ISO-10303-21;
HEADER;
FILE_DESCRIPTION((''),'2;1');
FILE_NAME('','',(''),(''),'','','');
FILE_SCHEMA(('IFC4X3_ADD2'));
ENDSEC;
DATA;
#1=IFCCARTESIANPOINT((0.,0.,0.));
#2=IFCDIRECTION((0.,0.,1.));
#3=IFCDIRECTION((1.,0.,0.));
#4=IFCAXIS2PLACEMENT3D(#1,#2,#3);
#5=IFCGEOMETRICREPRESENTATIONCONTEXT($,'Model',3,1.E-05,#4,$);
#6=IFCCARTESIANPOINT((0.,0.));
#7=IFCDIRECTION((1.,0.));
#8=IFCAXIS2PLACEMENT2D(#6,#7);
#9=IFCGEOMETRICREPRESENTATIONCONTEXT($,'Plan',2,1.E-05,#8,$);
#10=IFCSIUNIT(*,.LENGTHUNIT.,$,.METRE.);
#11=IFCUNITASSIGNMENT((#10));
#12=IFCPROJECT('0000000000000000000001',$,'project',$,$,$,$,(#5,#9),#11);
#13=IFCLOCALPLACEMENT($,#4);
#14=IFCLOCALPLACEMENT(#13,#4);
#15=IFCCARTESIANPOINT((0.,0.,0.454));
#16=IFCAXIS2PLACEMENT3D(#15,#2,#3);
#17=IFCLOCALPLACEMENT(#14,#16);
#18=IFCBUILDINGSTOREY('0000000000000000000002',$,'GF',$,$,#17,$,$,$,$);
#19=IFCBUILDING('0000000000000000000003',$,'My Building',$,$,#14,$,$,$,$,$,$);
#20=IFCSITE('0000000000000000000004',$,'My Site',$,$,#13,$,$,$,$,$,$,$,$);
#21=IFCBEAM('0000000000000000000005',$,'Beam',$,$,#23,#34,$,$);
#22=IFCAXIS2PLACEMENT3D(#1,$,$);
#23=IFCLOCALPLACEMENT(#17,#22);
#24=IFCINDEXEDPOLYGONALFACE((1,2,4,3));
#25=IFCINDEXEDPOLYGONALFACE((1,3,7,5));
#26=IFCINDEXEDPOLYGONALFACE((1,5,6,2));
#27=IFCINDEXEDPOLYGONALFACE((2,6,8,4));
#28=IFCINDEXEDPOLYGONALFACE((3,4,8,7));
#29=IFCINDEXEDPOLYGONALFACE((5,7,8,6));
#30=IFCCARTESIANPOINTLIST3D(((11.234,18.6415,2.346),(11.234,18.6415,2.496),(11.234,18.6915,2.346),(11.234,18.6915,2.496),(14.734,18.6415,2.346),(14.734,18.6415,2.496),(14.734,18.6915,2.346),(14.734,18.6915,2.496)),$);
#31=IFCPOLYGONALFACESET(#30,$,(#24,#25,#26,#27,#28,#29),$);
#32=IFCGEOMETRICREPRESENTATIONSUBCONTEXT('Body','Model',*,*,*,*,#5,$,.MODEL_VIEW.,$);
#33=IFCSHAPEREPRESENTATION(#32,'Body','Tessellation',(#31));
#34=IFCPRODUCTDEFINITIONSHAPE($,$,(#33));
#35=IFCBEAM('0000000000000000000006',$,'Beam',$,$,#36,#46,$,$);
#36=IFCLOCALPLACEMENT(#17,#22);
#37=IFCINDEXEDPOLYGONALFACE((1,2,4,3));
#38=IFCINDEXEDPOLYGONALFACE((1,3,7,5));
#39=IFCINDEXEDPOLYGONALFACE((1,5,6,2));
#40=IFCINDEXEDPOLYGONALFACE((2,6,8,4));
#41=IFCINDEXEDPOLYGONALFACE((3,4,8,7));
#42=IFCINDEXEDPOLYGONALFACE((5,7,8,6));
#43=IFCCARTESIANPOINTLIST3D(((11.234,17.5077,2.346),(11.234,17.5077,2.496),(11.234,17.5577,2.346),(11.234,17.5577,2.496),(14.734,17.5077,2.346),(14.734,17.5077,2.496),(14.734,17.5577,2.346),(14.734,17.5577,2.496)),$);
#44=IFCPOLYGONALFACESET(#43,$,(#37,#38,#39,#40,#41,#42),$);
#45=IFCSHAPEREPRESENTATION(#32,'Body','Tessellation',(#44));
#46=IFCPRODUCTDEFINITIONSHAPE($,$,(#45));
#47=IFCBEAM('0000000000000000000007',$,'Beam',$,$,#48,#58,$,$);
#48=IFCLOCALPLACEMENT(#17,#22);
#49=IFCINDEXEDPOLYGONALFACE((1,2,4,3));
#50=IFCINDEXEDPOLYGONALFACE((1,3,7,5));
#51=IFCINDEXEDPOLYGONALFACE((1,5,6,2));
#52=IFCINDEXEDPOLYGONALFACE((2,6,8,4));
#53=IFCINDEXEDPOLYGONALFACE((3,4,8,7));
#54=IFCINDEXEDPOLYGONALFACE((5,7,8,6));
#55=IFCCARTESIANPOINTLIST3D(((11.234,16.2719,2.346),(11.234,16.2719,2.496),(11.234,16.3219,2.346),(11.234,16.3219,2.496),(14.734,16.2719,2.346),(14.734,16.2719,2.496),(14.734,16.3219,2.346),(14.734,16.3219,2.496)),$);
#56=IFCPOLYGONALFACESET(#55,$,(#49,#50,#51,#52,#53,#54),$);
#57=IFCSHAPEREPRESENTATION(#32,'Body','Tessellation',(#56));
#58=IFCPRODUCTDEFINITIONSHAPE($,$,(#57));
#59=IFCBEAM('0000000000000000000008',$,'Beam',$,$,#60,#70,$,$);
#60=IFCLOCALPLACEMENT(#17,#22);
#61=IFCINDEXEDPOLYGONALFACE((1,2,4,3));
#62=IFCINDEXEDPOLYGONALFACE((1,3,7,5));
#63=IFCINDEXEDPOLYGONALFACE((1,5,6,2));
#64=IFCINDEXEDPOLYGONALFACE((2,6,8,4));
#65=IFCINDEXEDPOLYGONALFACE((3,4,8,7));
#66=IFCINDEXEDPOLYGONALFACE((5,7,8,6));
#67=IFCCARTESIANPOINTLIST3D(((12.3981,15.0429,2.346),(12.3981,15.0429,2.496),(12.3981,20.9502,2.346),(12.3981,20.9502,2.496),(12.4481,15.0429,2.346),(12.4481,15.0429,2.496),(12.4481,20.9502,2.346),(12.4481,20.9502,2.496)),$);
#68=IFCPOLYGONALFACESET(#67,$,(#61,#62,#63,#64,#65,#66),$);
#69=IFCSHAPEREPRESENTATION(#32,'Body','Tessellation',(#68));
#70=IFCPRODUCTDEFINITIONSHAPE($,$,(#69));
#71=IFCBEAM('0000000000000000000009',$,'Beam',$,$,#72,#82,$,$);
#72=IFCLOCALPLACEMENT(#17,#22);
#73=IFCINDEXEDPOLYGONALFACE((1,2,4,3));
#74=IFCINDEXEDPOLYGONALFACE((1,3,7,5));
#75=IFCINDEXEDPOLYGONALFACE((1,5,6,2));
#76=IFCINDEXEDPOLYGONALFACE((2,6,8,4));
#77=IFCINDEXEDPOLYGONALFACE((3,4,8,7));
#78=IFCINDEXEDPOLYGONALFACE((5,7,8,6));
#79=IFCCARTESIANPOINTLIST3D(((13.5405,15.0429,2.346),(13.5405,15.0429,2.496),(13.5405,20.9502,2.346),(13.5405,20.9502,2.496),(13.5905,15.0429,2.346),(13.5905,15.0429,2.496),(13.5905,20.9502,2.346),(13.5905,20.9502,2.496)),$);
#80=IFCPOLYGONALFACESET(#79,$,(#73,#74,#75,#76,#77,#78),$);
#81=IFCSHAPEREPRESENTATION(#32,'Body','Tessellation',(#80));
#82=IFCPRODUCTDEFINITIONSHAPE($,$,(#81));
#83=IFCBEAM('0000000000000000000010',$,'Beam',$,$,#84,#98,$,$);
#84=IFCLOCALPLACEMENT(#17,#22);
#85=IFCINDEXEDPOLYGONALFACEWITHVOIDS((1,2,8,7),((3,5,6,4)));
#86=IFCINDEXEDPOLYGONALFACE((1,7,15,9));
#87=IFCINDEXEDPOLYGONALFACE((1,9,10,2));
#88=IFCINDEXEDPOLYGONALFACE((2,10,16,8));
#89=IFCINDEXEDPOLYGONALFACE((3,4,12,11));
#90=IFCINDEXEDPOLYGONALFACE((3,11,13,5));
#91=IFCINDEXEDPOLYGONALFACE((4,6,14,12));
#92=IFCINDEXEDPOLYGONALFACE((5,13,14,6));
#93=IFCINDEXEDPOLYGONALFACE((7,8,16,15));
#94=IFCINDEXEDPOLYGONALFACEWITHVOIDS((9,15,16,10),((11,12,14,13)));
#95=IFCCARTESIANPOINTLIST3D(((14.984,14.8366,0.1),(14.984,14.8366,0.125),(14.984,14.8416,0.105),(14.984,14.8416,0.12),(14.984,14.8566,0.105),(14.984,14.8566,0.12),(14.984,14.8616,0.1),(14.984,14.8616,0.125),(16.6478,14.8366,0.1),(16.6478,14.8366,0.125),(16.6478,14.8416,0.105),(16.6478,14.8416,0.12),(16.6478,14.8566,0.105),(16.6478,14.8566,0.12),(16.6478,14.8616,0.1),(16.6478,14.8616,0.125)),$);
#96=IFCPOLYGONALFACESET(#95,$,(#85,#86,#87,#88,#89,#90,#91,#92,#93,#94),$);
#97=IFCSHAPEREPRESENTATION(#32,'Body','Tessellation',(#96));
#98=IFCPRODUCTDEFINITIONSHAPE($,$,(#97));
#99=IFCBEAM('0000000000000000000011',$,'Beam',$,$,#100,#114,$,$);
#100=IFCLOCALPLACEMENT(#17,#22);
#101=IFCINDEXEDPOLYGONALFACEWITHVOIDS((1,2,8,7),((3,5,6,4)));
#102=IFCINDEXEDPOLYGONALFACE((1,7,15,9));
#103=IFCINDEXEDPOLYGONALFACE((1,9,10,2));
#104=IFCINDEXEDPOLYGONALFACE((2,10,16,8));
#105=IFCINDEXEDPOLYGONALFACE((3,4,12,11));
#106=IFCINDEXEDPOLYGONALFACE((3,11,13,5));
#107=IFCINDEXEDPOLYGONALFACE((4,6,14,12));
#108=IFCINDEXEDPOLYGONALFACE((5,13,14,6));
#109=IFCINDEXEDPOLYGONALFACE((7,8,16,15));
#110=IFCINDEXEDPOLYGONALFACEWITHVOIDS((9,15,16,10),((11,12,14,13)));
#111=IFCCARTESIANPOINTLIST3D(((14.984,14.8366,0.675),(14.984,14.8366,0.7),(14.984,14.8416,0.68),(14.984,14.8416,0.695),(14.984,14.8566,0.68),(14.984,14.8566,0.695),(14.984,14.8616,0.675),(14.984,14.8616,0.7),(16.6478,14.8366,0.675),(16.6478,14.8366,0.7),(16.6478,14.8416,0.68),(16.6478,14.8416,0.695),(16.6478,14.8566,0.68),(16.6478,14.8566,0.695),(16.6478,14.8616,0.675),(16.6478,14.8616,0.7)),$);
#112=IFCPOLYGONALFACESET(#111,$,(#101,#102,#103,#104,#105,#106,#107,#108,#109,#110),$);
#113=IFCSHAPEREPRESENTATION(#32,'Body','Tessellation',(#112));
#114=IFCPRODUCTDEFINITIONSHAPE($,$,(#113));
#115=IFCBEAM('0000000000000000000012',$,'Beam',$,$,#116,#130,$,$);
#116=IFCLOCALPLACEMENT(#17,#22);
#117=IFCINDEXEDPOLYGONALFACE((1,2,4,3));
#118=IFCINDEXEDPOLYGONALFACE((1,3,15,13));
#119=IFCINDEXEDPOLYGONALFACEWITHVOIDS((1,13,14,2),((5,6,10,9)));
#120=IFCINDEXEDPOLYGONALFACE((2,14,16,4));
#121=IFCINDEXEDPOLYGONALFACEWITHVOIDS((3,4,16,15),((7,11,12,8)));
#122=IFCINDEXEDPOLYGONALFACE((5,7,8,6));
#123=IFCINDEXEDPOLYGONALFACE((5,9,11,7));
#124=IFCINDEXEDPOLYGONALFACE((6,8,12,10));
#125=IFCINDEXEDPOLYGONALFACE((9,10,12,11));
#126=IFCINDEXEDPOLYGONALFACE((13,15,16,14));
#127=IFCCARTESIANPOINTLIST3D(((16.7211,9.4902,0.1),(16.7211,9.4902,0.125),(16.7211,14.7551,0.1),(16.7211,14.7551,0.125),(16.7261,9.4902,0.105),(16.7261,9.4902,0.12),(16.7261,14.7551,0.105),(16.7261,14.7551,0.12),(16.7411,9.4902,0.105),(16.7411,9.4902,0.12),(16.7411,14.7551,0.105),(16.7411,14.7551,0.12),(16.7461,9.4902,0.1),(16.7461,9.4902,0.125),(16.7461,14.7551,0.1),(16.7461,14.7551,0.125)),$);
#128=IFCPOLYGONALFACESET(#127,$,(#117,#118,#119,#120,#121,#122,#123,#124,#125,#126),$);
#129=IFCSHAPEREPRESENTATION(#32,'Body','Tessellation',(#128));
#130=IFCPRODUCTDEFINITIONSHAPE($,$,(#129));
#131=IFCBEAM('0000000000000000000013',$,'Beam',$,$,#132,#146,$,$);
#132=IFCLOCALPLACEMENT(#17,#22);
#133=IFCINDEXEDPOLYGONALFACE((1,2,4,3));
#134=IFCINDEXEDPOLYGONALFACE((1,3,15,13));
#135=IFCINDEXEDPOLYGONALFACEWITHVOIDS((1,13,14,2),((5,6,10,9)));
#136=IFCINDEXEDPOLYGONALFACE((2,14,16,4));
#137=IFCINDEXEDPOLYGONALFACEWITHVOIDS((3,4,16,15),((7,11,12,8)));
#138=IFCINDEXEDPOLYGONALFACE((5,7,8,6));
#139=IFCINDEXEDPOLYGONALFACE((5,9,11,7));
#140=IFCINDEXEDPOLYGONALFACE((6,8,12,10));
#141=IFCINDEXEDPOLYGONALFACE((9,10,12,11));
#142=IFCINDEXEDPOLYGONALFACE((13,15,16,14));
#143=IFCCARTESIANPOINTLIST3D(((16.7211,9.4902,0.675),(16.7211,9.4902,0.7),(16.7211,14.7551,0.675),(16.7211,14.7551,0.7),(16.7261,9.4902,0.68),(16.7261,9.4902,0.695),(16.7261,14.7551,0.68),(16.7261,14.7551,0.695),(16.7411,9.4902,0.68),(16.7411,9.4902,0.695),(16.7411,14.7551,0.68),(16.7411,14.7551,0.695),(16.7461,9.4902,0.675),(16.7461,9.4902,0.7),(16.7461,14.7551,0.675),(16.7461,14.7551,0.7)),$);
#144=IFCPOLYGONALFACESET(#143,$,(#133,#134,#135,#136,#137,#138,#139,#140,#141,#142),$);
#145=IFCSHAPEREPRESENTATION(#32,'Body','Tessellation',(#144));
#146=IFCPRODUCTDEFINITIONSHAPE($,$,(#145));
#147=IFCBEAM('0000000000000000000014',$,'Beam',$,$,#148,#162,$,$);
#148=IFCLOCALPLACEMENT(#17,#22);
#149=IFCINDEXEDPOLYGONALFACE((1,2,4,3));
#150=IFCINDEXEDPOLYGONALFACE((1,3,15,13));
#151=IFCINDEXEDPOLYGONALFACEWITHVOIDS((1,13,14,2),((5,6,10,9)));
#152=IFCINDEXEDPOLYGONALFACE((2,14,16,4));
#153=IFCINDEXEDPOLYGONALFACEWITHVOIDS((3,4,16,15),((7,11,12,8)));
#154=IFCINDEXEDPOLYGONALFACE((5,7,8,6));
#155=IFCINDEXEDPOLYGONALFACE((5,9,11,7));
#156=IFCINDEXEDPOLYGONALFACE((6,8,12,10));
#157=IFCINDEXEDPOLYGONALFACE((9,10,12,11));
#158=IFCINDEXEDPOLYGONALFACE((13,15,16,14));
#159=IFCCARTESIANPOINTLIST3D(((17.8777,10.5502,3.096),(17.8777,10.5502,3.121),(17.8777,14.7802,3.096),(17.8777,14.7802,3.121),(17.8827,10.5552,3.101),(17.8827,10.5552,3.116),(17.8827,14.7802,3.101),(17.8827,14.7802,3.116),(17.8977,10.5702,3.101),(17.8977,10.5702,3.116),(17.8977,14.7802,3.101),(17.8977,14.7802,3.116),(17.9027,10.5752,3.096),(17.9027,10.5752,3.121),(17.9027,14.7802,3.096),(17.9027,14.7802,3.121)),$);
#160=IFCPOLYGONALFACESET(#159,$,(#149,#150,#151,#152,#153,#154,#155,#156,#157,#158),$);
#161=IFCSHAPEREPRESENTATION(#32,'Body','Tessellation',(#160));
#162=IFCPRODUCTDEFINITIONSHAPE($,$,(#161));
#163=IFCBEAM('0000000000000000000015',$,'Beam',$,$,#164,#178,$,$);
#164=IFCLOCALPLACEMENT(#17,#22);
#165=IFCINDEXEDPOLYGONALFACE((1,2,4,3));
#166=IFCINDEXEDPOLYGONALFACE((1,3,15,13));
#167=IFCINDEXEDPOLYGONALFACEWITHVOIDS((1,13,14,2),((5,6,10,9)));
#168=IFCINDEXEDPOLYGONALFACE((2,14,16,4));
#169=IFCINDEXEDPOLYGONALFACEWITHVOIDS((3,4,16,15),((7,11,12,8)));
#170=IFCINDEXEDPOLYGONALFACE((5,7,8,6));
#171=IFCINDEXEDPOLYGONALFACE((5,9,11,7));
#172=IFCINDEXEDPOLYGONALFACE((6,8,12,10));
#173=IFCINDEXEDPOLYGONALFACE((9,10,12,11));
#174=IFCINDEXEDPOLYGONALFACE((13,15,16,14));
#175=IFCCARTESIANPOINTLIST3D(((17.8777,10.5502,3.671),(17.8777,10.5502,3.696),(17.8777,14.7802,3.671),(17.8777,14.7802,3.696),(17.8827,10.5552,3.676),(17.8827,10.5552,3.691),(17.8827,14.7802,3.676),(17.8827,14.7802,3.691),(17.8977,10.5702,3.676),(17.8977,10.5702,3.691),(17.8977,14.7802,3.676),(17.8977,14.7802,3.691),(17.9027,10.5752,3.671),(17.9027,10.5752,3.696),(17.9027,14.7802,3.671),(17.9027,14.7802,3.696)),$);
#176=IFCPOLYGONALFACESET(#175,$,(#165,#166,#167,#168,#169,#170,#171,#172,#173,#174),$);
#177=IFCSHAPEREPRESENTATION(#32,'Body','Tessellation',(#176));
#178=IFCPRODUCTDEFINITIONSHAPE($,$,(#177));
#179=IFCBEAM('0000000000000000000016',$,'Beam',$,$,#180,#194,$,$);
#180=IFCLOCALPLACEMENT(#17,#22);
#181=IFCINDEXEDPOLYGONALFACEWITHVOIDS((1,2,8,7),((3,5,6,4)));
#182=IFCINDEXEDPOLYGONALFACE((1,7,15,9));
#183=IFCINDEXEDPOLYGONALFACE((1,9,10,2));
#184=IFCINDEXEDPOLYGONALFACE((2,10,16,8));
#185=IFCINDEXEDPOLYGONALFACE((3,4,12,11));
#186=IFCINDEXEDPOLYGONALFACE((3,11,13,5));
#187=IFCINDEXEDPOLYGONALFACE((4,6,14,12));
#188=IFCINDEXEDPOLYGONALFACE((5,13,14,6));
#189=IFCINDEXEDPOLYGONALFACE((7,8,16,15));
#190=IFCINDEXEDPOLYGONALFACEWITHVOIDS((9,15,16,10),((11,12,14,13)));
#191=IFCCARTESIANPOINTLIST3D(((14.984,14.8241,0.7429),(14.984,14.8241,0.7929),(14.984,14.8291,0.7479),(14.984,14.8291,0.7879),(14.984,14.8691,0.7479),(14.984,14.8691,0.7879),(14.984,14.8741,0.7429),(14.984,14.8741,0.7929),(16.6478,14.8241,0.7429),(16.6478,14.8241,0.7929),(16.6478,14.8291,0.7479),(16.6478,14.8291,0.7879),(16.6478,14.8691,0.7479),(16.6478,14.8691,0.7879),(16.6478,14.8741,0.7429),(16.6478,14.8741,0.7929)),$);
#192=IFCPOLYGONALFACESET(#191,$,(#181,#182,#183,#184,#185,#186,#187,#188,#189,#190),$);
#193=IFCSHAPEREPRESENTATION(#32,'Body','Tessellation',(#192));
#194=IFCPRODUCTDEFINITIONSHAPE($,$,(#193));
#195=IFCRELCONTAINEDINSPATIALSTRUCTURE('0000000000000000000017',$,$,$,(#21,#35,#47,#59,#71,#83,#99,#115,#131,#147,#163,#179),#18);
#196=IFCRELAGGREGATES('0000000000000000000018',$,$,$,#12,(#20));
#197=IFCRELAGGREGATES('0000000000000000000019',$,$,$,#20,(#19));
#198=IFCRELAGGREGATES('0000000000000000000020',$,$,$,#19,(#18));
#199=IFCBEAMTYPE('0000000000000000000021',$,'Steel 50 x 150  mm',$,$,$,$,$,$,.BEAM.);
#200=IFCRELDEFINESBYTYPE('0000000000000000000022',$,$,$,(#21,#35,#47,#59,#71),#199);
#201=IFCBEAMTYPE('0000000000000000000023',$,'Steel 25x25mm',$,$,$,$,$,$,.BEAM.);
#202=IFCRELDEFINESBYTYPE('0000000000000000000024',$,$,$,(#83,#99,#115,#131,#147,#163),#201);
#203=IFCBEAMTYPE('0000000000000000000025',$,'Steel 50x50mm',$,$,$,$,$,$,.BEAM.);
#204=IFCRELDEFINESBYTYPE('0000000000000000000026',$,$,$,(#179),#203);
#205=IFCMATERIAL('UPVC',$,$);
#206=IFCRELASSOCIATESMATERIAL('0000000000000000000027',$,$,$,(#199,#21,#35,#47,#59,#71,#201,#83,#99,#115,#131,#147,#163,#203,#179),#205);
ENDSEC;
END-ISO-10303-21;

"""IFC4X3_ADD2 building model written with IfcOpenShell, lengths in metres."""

from ifc_helpers import new_model, si_unit, frame, origin_with_axes, origin_2d_with_axis, place, context, subcontext, project, spatial, rectangle, hollow_rectangle, extrude, clip, halfspace, material, material_profile, profile_set, profile_usage, type_object, element, save


model = new_model("IFC4X3_ADD2")

# Units and contexts
model_context = context("Model", 3, precision=1e-05, world=origin_with_axes())
plan_context = context("Plan", 2, precision=1e-05, world=origin_2d_with_axis())
body_context = subcontext(model_context, "Body", "Model", "MODEL_VIEW")
ifc_project = project(units=[si_unit("LENGTHUNIT", "METRE")], contexts=[model_context, plan_context])

# Site, building, storey
site_placement = place(None, origin_with_axes())
site = spatial("IfcSite", under=ifc_project, at=site_placement, Name="My Site")
building_placement = place(site_placement, origin_with_axes())
building = spatial("IfcBuilding", under=site, at=building_placement, Name="My Building")
storey_placement = place(building_placement, frame((0.0, 0.0, 0.454), z_axis=(0.0, 0.0, 1.0), x_axis=(1.0, 0.0, 0.0)))
storey = spatial("IfcBuildingStorey", under=building, at=storey_placement, Name="GF")

# Shared definitions
ifc_material_1 = material(Name="UPVC")

# Beams
ifc_material_profile_1 = material_profile(ifc_material_1, rectangle(XDim=0.05, YDim=0.15))
ifc_profile_set_1 = profile_set([ifc_material_profile_1])
beam_type_1 = type_object("IfcBeamType", Name="Steel 50 x 150  mm", PredefinedType="BEAM", material=ifc_profile_set_1)
ifc_profile_usage_1 = profile_usage(ifc_profile_set_1)
beam_1_placement = place(storey_placement, frame((11.234, 18.6665, 2.421), z_axis=(1.0, 0.0, 0.0), x_axis=(0.0, 1.0, 0.0)))
element("IfcBeam", 1, at=beam_1_placement, inside=storey, type_object=beam_type_1, material=ifc_profile_usage_1, Name="Beam", context=body_context, shape_type="SweptSolid", body=[
    extrude(rectangle(XDim=0.05, YDim=0.15), origin_with_axes(), (0.0, 0.0, 1.0), 3.5),
])
ifc_profile_usage_2 = profile_usage(ifc_profile_set_1)
beam_2_placement = place(storey_placement, frame((11.234, 17.5327, 2.421), z_axis=(1.0, 0.0, 0.0), x_axis=(0.0, 1.0, 0.0)))
element("IfcBeam", 2, at=beam_2_placement, inside=storey, type_object=beam_type_1, material=ifc_profile_usage_2, Name="Beam", context=body_context, shape_type="SweptSolid", body=[
    extrude(rectangle(XDim=0.05, YDim=0.15), origin_with_axes(), (0.0, 0.0, 1.0), 3.5),
])
ifc_profile_usage_3 = profile_usage(ifc_profile_set_1)
beam_3_placement = place(storey_placement, frame((11.234, 16.2969, 2.421), z_axis=(1.0, 0.0, 0.0), x_axis=(0.0, 1.0, 0.0)))
element("IfcBeam", 3, at=beam_3_placement, inside=storey, type_object=beam_type_1, material=ifc_profile_usage_3, Name="Beam", context=body_context, shape_type="SweptSolid", body=[
    extrude(rectangle(XDim=0.05, YDim=0.15), origin_with_axes(), (0.0, 0.0, 1.0), 3.5),
])
ifc_profile_usage_4 = profile_usage(ifc_profile_set_1)
beam_4_placement = place(storey_placement, frame((12.4231, 15.0429, 2.421), z_axis=(0.0, 1.0, 0.0), x_axis=(-1.0, 0.0, 0.0)))
element("IfcBeam", 4, at=beam_4_placement, inside=storey, type_object=beam_type_1, material=ifc_profile_usage_4, Name="Beam", context=body_context, shape_type="SweptSolid", body=[
    extrude(rectangle(XDim=0.05, YDim=0.15), origin_with_axes(), (0.0, 0.0, 1.0), 5.9073),
])
ifc_profile_usage_5 = profile_usage(ifc_profile_set_1)
beam_5_placement = place(storey_placement, frame((13.5655, 15.0429, 2.421), z_axis=(0.0, 1.0, 0.0), x_axis=(-1.0, 0.0, 0.0)))
element("IfcBeam", 5, at=beam_5_placement, inside=storey, type_object=beam_type_1, material=ifc_profile_usage_5, Name="Beam", context=body_context, shape_type="SweptSolid", body=[
    extrude(rectangle(XDim=0.05, YDim=0.15), origin_with_axes(), (0.0, 0.0, 1.0), 5.9073),
])
ifc_material_profile_2 = material_profile(ifc_material_1, hollow_rectangle(XDim=0.025, YDim=0.025, WallThickness=0.005))
ifc_profile_set_2 = profile_set([ifc_material_profile_2])
ifc_profile_usage_6 = profile_usage(ifc_profile_set_2)
beam_type_2 = type_object("IfcBeamType", Name="Steel 25x25mm", PredefinedType="BEAM", material=ifc_profile_set_2)
beam_6_placement = place(storey_placement, frame((14.984, 14.8491, 0.1125), z_axis=(1.0, 0.0, 0.0), x_axis=(0.0, 1.0, 0.0)))
element("IfcBeam", 6, at=beam_6_placement, inside=storey, type_object=beam_type_2, material=ifc_profile_usage_6, Name="Beam", context=body_context, shape_type="SweptSolid", body=[
    extrude(hollow_rectangle(XDim=0.025, YDim=0.025, WallThickness=0.005), origin_with_axes(), (0.0, 0.0, 1.0), 1.6638),
])
ifc_profile_usage_7 = profile_usage(ifc_profile_set_2)
beam_7_placement = place(storey_placement, frame((14.984, 14.8491, 0.6875), z_axis=(1.0, 0.0, 0.0), x_axis=(0.0, 1.0, 0.0)))
element("IfcBeam", 7, at=beam_7_placement, inside=storey, type_object=beam_type_2, material=ifc_profile_usage_7, Name="Beam", context=body_context, shape_type="SweptSolid", body=[
    extrude(hollow_rectangle(XDim=0.025, YDim=0.025, WallThickness=0.005), origin_with_axes(), (0.0, 0.0, 1.0), 1.6638),
])
ifc_profile_usage_8 = profile_usage(ifc_profile_set_2)
beam_8_placement = place(storey_placement, frame((16.7336, 14.7551, 0.1125), z_axis=(0.0, -1.0, 0.0), x_axis=(1.0, 0.0, 0.0)))
element("IfcBeam", 8, at=beam_8_placement, inside=storey, type_object=beam_type_2, material=ifc_profile_usage_8, Name="Beam", context=body_context, shape_type="SweptSolid", body=[
    extrude(hollow_rectangle(XDim=0.025, YDim=0.025, WallThickness=0.005), origin_with_axes(), (0.0, 0.0, 1.0), 5.2649),
])
ifc_profile_usage_9 = profile_usage(ifc_profile_set_2)
beam_9_placement = place(storey_placement, frame((16.7336, 14.7551, 0.6875), z_axis=(0.0, -1.0, 0.0), x_axis=(1.0, 0.0, 0.0)))
element("IfcBeam", 9, at=beam_9_placement, inside=storey, type_object=beam_type_2, material=ifc_profile_usage_9, Name="Beam", context=body_context, shape_type="SweptSolid", body=[
    extrude(hollow_rectangle(XDim=0.025, YDim=0.025, WallThickness=0.005), origin_with_axes(), (0.0, 0.0, 1.0), 5.2649),
])
ifc_profile_usage_10 = profile_usage(ifc_profile_set_2)
beam_10_placement = place(storey_placement, frame((17.8902, 14.7802, 3.1085), z_axis=(0.0, -1.0, 0.0), x_axis=(1.0, 0.0, 0.0)))
element("IfcBeam", 10, at=beam_10_placement, inside=storey, type_object=beam_type_2, material=ifc_profile_usage_10, Name="Beam", context=body_context, shape_type="Clipping", body=[
    clip(extrude(hollow_rectangle(XDim=0.025, YDim=0.025, WallThickness=0.005), origin_with_axes(), (0.0, 0.0, 1.0), 4.23), halfspace(frame((-0.0125, -3.5625, 4.23), z_axis=(0.70708, 0.0, 0.707134), x_axis=(0.0, -1.0, 0.0)), False)),
])
ifc_profile_usage_11 = profile_usage(ifc_profile_set_2)
beam_11_placement = place(storey_placement, frame((17.8902, 14.7802, 3.6835), z_axis=(0.0, -1.0, 0.0), x_axis=(1.0, 0.0, 0.0)))
element("IfcBeam", 11, at=beam_11_placement, inside=storey, type_object=beam_type_2, material=ifc_profile_usage_11, Name="Beam", context=body_context, shape_type="Clipping", body=[
    clip(extrude(hollow_rectangle(XDim=0.025, YDim=0.025, WallThickness=0.005), origin_with_axes(), (0.0, 0.0, 1.0), 4.23), halfspace(frame((-0.0125, -4.1375, 4.23), z_axis=(0.70708, 0.0, 0.707134), x_axis=(0.0, -1.0, 0.0)), False)),
])
ifc_material_profile_3 = material_profile(ifc_material_1, hollow_rectangle(XDim=0.05, YDim=0.05, WallThickness=0.005))
ifc_profile_set_3 = profile_set([ifc_material_profile_3])
ifc_profile_usage_12 = profile_usage(ifc_profile_set_3)
beam_type_3 = type_object("IfcBeamType", Name="Steel 50x50mm", PredefinedType="BEAM", material=ifc_profile_set_3)
beam_12_placement = place(storey_placement, frame((14.984, 14.8491, 0.7679), z_axis=(1.0, 0.0, 0.0), x_axis=(0.0, 1.0, 0.0)))
element("IfcBeam", 12, at=beam_12_placement, inside=storey, type_object=beam_type_3, material=ifc_profile_usage_12, Name="Beam", context=body_context, shape_type="SweptSolid", body=[
    extrude(hollow_rectangle(XDim=0.05, YDim=0.05, WallThickness=0.005), origin_with_axes(), (0.0, 0.0, 1.0), 1.6638),
])

save(model, "model.ifc")
